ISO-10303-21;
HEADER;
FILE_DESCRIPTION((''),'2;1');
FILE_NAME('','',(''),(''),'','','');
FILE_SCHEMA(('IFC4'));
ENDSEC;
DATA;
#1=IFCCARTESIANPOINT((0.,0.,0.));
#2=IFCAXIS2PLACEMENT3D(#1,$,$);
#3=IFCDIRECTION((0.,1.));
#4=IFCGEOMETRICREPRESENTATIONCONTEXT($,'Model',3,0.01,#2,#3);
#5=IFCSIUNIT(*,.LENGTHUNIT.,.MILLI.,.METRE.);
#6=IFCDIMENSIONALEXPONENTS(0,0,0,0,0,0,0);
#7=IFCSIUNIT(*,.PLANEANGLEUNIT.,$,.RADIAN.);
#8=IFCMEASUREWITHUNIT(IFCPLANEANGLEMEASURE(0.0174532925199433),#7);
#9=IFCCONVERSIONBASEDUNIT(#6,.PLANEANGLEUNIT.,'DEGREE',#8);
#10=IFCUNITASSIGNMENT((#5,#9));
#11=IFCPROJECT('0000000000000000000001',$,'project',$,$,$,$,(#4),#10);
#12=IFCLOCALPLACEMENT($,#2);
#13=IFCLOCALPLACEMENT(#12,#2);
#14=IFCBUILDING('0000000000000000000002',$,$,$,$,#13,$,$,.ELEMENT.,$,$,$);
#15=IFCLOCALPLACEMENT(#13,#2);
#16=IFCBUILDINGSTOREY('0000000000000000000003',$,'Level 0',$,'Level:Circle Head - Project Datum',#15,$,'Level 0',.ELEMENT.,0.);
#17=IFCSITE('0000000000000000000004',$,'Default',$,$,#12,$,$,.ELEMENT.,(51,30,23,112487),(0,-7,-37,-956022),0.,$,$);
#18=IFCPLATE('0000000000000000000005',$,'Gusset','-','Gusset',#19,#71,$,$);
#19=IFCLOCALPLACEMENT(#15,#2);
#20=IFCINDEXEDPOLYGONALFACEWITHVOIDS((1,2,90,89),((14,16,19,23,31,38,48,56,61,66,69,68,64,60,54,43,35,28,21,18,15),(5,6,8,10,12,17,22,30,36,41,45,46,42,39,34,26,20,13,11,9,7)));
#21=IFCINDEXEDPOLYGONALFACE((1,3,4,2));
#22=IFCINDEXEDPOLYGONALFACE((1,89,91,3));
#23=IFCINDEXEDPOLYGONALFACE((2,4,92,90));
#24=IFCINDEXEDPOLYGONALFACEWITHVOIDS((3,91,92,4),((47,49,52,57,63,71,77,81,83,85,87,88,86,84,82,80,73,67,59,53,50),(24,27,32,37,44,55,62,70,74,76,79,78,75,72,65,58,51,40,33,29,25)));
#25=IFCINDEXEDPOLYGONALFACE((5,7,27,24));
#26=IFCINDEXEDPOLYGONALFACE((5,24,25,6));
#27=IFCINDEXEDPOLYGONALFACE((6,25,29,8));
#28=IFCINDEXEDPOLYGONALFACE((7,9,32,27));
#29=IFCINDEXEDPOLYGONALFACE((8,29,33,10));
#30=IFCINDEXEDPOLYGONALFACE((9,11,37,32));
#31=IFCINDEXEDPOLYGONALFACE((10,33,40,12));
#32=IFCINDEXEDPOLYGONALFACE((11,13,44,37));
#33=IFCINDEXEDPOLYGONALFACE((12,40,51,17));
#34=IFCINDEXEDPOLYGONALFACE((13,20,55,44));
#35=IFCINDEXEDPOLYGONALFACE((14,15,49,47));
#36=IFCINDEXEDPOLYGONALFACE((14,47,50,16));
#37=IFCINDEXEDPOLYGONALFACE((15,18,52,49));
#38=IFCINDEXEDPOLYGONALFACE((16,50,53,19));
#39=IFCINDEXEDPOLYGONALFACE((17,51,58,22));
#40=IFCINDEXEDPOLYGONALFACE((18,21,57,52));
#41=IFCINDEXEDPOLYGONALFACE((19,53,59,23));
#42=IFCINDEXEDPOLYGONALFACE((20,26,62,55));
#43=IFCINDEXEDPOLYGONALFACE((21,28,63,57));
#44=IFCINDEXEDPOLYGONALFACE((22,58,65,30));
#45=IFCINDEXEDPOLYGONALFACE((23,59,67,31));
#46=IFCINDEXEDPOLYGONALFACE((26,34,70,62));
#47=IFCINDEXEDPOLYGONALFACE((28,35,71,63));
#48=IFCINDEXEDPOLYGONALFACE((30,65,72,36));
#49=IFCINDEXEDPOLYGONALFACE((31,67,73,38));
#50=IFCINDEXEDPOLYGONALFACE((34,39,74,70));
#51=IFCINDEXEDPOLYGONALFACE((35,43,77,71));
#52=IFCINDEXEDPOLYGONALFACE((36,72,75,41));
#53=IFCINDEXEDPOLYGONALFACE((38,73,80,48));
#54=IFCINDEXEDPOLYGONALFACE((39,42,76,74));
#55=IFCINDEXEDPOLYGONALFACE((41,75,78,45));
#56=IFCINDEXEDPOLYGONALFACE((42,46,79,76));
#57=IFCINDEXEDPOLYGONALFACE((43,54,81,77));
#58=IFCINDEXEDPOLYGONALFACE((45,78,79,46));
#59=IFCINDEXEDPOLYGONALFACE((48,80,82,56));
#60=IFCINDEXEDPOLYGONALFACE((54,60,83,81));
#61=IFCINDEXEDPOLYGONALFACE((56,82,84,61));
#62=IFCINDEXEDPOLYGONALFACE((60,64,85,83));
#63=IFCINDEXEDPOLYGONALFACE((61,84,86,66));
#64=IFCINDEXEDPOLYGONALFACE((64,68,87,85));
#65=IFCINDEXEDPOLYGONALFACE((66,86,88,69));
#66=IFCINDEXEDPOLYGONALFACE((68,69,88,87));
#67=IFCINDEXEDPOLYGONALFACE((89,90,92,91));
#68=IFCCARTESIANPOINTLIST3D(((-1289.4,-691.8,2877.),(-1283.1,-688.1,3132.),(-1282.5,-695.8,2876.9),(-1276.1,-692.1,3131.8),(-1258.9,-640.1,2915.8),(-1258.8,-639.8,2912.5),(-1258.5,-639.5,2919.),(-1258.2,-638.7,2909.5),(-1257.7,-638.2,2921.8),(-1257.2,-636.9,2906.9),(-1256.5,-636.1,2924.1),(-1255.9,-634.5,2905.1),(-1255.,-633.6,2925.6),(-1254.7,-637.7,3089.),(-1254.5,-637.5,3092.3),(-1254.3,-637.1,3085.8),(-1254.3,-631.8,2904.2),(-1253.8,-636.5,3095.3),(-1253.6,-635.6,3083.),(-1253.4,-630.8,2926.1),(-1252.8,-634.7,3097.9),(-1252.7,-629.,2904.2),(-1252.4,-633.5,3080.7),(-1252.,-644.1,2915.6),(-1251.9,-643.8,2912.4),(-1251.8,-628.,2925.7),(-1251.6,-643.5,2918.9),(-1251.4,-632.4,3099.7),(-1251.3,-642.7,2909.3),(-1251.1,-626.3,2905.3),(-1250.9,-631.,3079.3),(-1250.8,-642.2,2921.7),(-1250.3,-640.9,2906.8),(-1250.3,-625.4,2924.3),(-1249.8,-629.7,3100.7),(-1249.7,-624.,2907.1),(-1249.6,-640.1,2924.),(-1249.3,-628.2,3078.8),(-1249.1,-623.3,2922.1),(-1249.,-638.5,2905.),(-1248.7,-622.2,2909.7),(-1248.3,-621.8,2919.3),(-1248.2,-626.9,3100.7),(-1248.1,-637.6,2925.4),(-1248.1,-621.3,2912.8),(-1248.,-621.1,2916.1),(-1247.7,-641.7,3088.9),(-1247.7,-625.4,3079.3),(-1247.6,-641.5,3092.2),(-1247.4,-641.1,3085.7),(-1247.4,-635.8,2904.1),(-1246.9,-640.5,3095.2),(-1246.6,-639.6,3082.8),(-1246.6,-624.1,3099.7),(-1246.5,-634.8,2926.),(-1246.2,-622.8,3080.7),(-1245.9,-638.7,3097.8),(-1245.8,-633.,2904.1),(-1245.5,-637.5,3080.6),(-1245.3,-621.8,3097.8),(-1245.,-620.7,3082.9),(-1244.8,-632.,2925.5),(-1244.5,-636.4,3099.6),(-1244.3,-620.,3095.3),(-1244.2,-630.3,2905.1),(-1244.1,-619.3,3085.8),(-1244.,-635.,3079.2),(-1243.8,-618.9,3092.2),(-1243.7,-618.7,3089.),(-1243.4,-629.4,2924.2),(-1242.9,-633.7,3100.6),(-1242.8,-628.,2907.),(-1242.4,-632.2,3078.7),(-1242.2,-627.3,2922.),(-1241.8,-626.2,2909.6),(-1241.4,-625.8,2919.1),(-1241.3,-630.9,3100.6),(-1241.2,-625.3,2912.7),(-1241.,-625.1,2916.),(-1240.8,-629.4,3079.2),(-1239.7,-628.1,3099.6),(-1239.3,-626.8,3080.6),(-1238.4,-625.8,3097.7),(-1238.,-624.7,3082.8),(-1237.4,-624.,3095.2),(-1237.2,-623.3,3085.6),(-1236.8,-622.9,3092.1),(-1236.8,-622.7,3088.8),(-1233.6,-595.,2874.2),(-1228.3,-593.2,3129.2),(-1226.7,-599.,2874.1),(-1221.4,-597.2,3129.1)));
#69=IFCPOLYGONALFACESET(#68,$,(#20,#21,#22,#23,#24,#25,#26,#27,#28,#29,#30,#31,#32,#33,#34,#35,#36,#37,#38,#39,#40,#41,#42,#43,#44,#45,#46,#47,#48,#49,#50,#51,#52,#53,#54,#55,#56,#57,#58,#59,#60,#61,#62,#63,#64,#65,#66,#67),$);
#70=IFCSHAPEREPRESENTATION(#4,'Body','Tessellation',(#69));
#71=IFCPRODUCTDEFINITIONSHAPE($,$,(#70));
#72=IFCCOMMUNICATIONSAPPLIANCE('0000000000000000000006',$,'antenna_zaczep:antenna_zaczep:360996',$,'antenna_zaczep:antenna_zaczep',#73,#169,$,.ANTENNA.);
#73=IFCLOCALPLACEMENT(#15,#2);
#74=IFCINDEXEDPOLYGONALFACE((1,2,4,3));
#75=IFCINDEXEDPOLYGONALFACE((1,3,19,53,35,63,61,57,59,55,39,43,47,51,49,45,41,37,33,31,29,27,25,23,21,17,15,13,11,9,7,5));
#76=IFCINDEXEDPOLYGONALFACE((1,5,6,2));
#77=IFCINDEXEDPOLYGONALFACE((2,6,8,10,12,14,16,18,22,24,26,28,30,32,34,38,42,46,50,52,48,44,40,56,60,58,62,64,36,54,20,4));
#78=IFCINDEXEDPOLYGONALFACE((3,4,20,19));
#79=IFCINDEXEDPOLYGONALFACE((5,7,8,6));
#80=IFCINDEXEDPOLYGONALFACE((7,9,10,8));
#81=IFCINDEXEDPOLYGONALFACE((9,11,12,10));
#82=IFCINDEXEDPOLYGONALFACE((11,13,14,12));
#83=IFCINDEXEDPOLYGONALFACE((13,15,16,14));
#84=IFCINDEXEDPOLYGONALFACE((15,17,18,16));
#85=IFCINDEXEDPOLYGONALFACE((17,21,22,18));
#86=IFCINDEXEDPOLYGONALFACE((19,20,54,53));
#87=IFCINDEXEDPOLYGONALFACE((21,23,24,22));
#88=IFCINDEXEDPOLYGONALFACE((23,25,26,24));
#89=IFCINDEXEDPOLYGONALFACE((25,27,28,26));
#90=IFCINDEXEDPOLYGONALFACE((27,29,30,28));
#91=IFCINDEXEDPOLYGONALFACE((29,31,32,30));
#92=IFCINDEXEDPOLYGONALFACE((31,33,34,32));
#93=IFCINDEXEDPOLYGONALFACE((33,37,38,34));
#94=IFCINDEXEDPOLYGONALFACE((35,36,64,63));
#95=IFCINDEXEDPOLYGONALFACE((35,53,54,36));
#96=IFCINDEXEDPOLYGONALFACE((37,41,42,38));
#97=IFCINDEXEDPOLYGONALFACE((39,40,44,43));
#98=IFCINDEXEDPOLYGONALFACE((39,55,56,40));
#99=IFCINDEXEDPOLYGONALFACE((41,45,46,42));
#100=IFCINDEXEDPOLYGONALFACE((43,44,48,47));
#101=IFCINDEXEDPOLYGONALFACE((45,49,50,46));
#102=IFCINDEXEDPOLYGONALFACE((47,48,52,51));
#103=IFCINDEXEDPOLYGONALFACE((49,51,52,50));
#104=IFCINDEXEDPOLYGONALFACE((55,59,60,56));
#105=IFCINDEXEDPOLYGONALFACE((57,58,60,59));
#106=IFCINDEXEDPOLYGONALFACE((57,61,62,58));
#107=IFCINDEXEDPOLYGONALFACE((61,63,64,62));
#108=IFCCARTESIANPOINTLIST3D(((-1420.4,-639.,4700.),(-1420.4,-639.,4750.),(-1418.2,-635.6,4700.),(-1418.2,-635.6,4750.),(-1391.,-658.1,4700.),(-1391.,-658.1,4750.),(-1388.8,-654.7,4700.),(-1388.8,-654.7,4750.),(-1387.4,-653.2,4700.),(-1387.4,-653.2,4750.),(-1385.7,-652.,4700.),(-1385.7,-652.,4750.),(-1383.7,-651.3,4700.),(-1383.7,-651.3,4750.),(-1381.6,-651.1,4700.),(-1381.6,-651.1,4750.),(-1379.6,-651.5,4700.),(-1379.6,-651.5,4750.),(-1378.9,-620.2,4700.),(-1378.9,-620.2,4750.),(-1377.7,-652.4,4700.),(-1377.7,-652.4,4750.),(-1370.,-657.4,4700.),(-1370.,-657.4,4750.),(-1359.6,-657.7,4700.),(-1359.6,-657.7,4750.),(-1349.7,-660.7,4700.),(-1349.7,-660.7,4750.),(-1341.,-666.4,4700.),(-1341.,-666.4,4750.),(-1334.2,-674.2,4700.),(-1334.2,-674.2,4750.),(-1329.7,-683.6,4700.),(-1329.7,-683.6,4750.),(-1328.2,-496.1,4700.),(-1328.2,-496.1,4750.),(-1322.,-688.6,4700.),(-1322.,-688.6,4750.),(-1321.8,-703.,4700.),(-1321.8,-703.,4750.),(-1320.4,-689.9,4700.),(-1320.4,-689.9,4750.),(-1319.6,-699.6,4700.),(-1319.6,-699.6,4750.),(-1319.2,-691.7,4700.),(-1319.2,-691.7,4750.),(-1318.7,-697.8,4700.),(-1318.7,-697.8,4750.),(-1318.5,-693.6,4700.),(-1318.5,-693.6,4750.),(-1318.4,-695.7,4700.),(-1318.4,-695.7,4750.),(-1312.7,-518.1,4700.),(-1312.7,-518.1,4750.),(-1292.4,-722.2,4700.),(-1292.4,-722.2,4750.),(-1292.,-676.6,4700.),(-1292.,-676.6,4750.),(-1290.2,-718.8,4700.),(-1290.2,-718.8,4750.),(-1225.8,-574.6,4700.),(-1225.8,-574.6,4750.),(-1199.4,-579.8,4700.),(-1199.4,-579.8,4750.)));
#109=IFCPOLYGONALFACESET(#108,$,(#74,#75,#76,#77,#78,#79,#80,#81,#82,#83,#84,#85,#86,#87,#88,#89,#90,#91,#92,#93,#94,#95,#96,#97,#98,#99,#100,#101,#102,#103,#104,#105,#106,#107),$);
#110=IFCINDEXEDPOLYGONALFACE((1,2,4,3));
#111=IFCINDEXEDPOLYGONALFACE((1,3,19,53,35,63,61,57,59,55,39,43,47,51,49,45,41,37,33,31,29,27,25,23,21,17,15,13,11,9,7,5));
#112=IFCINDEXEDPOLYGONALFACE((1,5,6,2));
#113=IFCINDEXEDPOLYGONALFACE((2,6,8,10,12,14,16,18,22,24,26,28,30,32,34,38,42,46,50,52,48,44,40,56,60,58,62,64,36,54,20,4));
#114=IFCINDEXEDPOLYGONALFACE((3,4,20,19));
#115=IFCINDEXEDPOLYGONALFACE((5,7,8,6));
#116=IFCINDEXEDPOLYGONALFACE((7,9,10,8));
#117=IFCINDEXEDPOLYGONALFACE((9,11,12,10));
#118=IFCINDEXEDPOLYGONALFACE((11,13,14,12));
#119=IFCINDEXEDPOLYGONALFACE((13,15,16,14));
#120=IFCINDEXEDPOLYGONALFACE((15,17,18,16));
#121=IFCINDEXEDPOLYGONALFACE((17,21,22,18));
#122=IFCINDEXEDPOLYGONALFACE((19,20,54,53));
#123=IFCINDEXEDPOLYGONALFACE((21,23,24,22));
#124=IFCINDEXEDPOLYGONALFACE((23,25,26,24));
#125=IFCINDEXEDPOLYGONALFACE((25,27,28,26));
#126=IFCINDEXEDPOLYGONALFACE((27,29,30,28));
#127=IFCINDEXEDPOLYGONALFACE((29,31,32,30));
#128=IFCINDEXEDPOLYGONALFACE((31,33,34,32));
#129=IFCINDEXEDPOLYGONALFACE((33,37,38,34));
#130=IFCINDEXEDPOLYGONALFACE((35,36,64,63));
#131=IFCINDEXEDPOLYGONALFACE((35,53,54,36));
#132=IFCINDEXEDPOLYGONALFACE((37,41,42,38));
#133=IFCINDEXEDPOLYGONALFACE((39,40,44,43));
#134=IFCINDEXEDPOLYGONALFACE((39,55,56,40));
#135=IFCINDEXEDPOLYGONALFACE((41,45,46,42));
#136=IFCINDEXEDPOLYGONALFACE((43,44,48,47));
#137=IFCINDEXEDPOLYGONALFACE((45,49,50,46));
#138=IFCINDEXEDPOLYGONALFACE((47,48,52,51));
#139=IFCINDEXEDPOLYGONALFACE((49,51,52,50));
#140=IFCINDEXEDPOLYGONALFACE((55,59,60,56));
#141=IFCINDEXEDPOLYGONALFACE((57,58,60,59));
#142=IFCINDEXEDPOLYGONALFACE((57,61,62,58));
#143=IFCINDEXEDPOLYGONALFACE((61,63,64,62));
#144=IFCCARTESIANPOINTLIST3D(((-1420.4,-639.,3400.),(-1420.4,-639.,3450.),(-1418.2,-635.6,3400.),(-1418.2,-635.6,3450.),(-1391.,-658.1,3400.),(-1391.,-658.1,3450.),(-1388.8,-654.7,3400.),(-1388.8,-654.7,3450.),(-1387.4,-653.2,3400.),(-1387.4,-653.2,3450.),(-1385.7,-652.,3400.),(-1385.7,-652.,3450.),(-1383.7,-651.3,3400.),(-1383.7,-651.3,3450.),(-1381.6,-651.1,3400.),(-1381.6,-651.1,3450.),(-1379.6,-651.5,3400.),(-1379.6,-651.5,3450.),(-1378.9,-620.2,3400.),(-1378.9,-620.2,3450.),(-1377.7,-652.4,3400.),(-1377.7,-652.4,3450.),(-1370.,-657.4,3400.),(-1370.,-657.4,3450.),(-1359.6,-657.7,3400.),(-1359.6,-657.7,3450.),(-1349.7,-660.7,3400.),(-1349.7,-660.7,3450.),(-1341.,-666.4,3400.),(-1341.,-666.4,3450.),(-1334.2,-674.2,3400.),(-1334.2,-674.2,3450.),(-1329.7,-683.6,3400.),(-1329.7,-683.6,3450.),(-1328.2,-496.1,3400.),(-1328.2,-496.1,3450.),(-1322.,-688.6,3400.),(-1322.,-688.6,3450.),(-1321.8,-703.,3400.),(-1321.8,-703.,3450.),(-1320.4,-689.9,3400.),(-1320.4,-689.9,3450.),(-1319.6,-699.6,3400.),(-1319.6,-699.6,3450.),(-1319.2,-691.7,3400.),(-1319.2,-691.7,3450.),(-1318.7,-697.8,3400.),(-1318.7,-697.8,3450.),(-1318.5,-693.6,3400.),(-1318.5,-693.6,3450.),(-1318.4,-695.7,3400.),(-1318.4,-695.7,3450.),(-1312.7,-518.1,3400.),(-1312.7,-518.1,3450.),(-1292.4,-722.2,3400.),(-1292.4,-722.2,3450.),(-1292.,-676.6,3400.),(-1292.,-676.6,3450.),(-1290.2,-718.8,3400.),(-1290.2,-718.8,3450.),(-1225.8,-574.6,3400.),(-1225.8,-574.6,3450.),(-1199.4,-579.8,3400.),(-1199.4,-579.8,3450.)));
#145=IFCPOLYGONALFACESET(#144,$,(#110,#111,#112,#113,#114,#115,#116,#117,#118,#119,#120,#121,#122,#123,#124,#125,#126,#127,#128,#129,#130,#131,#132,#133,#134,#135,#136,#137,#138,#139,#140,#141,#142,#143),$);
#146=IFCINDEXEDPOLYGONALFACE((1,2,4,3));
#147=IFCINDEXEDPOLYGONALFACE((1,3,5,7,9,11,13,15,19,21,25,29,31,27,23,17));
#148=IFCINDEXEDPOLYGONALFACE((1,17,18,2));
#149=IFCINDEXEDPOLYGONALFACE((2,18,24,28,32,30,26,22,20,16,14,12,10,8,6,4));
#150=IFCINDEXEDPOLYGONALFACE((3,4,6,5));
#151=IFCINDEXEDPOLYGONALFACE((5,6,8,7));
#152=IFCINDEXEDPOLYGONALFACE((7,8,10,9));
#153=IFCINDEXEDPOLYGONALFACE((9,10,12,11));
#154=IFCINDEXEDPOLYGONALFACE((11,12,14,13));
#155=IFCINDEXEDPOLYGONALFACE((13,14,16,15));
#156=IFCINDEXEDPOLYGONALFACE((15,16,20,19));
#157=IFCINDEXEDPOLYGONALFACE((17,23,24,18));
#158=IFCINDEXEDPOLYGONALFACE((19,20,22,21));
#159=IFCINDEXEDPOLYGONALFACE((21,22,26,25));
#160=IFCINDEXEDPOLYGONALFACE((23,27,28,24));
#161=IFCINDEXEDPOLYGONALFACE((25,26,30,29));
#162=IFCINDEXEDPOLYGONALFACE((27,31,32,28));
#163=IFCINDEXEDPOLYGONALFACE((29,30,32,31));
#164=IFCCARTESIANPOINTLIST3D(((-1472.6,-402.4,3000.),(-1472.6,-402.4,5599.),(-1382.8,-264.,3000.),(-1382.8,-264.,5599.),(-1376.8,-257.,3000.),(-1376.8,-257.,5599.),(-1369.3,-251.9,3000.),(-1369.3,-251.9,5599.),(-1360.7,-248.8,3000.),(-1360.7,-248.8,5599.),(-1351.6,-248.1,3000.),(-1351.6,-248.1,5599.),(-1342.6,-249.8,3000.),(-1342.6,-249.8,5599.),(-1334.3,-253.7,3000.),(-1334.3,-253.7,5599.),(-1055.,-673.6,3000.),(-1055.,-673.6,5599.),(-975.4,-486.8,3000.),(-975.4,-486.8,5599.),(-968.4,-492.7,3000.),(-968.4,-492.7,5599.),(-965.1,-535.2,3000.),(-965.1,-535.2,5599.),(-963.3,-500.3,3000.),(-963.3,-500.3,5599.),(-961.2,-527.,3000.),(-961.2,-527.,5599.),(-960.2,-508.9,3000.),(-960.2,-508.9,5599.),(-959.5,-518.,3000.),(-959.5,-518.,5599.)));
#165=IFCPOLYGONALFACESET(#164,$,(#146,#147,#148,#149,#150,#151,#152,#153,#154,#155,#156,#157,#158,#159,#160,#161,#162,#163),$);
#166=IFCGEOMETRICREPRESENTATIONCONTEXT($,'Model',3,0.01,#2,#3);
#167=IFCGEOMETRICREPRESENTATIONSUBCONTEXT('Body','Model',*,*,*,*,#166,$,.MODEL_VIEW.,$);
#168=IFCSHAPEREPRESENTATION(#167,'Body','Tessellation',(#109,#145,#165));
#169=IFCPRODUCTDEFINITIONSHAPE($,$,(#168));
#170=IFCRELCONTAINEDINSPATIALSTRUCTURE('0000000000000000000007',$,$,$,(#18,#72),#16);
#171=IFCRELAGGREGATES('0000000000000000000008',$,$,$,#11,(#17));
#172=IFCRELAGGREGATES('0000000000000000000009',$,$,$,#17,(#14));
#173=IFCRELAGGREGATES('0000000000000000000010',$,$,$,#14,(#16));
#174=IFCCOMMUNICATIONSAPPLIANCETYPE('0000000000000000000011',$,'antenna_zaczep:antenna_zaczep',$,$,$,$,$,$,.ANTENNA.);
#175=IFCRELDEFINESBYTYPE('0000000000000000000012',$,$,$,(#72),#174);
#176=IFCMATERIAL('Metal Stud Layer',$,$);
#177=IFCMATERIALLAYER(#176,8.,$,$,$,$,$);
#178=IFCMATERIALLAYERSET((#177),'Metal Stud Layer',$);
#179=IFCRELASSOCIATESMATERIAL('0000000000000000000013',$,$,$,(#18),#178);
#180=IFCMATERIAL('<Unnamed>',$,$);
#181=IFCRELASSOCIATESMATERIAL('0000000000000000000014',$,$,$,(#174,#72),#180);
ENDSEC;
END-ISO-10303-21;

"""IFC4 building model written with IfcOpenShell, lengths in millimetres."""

from ifc_helpers import new_model, entity, si_unit, converted_unit, direction, frame, origin, origin_with_axes, origin_2d_with_axis, place, context, subcontext, project, spatial, polyline, line, arc, indexed_curve, circle, outline, extrude, source, transform, mapped, material, layer, layer_set, type_object, type_shapes, element, save


model = new_model("IFC4")

# Units and contexts
model_context_1 = context("Model", 3, precision=0.01, world=origin(), true_north=direction((0.0, 1.0)))
model_context_2 = context("Model", 3, precision=0.01, world=origin(), true_north=direction((0.0, 1.0)))
body_context = subcontext(model_context_2, "Body", "Model", "MODEL_VIEW")
ifc_project = project(units=[si_unit("LENGTHUNIT", "METRE", prefix="MILLI"), converted_unit("PLANEANGLEUNIT", "DEGREE", entity("IfcPlaneAngleMeasure", 0.0174532925199433), si_unit("PLANEANGLEUNIT", "RADIAN"), dimensions=[0, 0, 0, 0, 0, 0, 0])], contexts=[model_context_1])

# Site, building, storey
site_placement = place(None, origin())
site = spatial("IfcSite", under=ifc_project, at=site_placement, Name="Default", CompositionType="ELEMENT", RefLatitude=(51, 30, 23, 112487), RefLongitude=(0, -7, -37, -956022), RefElevation=0.0)
building_placement = place(site_placement, origin())
building = spatial("IfcBuilding", under=site, at=building_placement, CompositionType="ELEMENT")
storey_placement = place(building_placement, origin())
storey = spatial("IfcBuildingStorey", under=building, at=storey_placement, Name="Level 0", ObjectType="Level:Circle Head - Project Datum", LongName="Level 0", CompositionType="ELEMENT", Elevation=0.0)

# Plate, openings
ifc_material_1 = material(Name="Metal Stud Layer")
ifc_layer_1 = layer(ifc_material_1, 8.0)
ifc_layer_set_1 = layer_set([ifc_layer_1], Name="Metal Stud Layer")
plate_1_placement = place(storey_placement, frame((-1281.9, -686.2, 3131.9), z_axis=(0.865935, -0.499948, -0.014432), x_axis=(-0.02499, -0.014428, -0.999584)))
plate_1 = element("IfcPlate", 1, at=plate_1_placement, inside=storey, material=ifc_layer_set_1, Name="Gusset", Description="-", ObjectType="Gusset", context=model_context_1, shape_type="SweptSolid", body=[
    extrude(outline(polyline([(0.0, -2.3), (255.1, -2.3), (255.1, 109.5), (0.0, 107.4), (0.0, -2.3)])), origin_with_axes(), (0.0, 0.0, 1.0), 8.0),
])
opening_1_placement = place(plate_1_placement, frame((215.2, 67.8, 8.5), z_axis=(0.0, 0.0, -1.0), x_axis=(0.465435, 0.885082, 0.0)))
element("IfcOpeningElement", 2, at=opening_1_placement, cuts=plate_1, ObjectType="Opening", context=model_context_1, shape_type="SweptSolid", body=[
    extrude(circle(Radius=11.0, at=origin_2d_with_axis()), origin(), (0.0, 0.0, 1.0), 9.0),
])
opening_2_placement = place(plate_1_placement, frame((40.4, 67.6, 8.5), z_axis=(0.0, 0.0, -1.0), x_axis=(-0.519472, 0.854487, 0.0)))
element("IfcOpeningElement", 3, at=opening_2_placement, cuts=plate_1, ObjectType="Opening", context=model_context_1, shape_type="SweptSolid", body=[
    extrude(circle(Radius=11.0, at=origin_2d_with_axis()), origin(), (0.0, 0.0, 1.0), 9.0),
])

# Communications appliance
ifc_material_2 = material(Name="<Unnamed>")
communications_appliance_type = type_object("IfcCommunicationsApplianceType", Name="antenna_zaczep:antenna_zaczep", PredefinedType="ANTENNA", material=ifc_material_2)
shared_shape = source(origin(), body_context, "Body", "SweptSolid", [
    extrude(outline(indexed_curve([(-76.8, -125.5), (76.8, -125.5), (51.8, -115.5), (51.8, 6.1), (76.3, 40.5), (76.3, 44.5), (41.2, 44.5), (41.2, 40.5), (38.9, 34.8), (33.2, 32.5), (24.0, 32.5), (0.0, 23.9), (-24.0, 32.5), (-33.2, 32.5), (-38.9, 34.8), (-41.2, 40.5), (-41.2, 44.5), (-76.3, 44.5), (-76.3, 40.5), (-51.8, 6.1), (-51.8, -115.5)], segments=[line(1, 2, 3, 4, 5, 6, 7, 8), arc(8, 9, 10), line(10, 11), arc(11, 12, 13), line(13, 14), arc(14, 15, 16), line(16, 17, 18, 19, 20, 21, 1)], self_intersect=False)), frame((0.0, 61.4, 1700.0), z_axis=(0.0, 0.0, 1.0), x_axis=(-1.0, 0.0, 0.0)), (0.0, 0.0, 1.0), 50.0),
    extrude(outline(indexed_curve([(-76.8, -125.5), (76.8, -125.5), (51.8, -115.5), (51.8, 6.1), (76.3, 40.5), (76.3, 44.5), (41.2, 44.5), (41.2, 40.5), (38.9, 34.8), (33.2, 32.5), (24.0, 32.5), (0.0, 23.9), (-24.0, 32.5), (-33.2, 32.5), (-38.9, 34.8), (-41.2, 40.5), (-41.2, 44.5), (-76.3, 44.5), (-76.3, 40.5), (-51.8, 6.1), (-51.8, -115.5)], segments=[line(1, 2, 3, 4, 5, 6, 7, 8), arc(8, 9, 10), line(10, 11), arc(11, 12, 13), line(13, 14), arc(14, 15, 16), line(16, 17, 18, 19, 20, 21, 1)], self_intersect=False)), frame((0.0, 61.4, 400.0), z_axis=(0.0, 0.0, 1.0), x_axis=(-1.0, 0.0, 0.0)), (0.0, 0.0, 1.0), 50.0),
    extrude(outline(indexed_curve([(-214.0, -78.3), (214.0, -78.3), (238.7, -68.1), (249.0, -43.3), (249.0, 121.7), (-249.0, 121.7), (-249.0, -43.3), (-238.7, -68.1)], segments=[line(1, 2), arc(2, 3, 4), line(4, 5, 6, 7), arc(7, 8, 1)], self_intersect=False)), frame((0.0, 308.6, 0.0), z_axis=(0.0, 0.0, 1.0), x_axis=(-1.0, 0.0, 0.0)), (0.0, 0.0, 1.0), 2599.0),
])
type_shapes(communications_appliance_type, [shared_shape])
communications_appliance_placement = place(storey_placement, frame((-1365.6, -694.7, 3000.0), z_axis=(0.0, 0.0, 1.0), x_axis=(0.838671, -0.544639, 0.0)))
element("IfcCommunicationsAppliance", 4, at=communications_appliance_placement, inside=storey, type_object=communications_appliance_type, material=ifc_material_2, Name="antenna_zaczep:antenna_zaczep:360996", ObjectType="antenna_zaczep:antenna_zaczep", PredefinedType="ANTENNA", context=body_context, shape_type="MappedRepresentation", body=[
    mapped(shared_shape, transform((0.0, 0.0, 0.0), scale=1.0)),
])

save(model, "model.ifc")
